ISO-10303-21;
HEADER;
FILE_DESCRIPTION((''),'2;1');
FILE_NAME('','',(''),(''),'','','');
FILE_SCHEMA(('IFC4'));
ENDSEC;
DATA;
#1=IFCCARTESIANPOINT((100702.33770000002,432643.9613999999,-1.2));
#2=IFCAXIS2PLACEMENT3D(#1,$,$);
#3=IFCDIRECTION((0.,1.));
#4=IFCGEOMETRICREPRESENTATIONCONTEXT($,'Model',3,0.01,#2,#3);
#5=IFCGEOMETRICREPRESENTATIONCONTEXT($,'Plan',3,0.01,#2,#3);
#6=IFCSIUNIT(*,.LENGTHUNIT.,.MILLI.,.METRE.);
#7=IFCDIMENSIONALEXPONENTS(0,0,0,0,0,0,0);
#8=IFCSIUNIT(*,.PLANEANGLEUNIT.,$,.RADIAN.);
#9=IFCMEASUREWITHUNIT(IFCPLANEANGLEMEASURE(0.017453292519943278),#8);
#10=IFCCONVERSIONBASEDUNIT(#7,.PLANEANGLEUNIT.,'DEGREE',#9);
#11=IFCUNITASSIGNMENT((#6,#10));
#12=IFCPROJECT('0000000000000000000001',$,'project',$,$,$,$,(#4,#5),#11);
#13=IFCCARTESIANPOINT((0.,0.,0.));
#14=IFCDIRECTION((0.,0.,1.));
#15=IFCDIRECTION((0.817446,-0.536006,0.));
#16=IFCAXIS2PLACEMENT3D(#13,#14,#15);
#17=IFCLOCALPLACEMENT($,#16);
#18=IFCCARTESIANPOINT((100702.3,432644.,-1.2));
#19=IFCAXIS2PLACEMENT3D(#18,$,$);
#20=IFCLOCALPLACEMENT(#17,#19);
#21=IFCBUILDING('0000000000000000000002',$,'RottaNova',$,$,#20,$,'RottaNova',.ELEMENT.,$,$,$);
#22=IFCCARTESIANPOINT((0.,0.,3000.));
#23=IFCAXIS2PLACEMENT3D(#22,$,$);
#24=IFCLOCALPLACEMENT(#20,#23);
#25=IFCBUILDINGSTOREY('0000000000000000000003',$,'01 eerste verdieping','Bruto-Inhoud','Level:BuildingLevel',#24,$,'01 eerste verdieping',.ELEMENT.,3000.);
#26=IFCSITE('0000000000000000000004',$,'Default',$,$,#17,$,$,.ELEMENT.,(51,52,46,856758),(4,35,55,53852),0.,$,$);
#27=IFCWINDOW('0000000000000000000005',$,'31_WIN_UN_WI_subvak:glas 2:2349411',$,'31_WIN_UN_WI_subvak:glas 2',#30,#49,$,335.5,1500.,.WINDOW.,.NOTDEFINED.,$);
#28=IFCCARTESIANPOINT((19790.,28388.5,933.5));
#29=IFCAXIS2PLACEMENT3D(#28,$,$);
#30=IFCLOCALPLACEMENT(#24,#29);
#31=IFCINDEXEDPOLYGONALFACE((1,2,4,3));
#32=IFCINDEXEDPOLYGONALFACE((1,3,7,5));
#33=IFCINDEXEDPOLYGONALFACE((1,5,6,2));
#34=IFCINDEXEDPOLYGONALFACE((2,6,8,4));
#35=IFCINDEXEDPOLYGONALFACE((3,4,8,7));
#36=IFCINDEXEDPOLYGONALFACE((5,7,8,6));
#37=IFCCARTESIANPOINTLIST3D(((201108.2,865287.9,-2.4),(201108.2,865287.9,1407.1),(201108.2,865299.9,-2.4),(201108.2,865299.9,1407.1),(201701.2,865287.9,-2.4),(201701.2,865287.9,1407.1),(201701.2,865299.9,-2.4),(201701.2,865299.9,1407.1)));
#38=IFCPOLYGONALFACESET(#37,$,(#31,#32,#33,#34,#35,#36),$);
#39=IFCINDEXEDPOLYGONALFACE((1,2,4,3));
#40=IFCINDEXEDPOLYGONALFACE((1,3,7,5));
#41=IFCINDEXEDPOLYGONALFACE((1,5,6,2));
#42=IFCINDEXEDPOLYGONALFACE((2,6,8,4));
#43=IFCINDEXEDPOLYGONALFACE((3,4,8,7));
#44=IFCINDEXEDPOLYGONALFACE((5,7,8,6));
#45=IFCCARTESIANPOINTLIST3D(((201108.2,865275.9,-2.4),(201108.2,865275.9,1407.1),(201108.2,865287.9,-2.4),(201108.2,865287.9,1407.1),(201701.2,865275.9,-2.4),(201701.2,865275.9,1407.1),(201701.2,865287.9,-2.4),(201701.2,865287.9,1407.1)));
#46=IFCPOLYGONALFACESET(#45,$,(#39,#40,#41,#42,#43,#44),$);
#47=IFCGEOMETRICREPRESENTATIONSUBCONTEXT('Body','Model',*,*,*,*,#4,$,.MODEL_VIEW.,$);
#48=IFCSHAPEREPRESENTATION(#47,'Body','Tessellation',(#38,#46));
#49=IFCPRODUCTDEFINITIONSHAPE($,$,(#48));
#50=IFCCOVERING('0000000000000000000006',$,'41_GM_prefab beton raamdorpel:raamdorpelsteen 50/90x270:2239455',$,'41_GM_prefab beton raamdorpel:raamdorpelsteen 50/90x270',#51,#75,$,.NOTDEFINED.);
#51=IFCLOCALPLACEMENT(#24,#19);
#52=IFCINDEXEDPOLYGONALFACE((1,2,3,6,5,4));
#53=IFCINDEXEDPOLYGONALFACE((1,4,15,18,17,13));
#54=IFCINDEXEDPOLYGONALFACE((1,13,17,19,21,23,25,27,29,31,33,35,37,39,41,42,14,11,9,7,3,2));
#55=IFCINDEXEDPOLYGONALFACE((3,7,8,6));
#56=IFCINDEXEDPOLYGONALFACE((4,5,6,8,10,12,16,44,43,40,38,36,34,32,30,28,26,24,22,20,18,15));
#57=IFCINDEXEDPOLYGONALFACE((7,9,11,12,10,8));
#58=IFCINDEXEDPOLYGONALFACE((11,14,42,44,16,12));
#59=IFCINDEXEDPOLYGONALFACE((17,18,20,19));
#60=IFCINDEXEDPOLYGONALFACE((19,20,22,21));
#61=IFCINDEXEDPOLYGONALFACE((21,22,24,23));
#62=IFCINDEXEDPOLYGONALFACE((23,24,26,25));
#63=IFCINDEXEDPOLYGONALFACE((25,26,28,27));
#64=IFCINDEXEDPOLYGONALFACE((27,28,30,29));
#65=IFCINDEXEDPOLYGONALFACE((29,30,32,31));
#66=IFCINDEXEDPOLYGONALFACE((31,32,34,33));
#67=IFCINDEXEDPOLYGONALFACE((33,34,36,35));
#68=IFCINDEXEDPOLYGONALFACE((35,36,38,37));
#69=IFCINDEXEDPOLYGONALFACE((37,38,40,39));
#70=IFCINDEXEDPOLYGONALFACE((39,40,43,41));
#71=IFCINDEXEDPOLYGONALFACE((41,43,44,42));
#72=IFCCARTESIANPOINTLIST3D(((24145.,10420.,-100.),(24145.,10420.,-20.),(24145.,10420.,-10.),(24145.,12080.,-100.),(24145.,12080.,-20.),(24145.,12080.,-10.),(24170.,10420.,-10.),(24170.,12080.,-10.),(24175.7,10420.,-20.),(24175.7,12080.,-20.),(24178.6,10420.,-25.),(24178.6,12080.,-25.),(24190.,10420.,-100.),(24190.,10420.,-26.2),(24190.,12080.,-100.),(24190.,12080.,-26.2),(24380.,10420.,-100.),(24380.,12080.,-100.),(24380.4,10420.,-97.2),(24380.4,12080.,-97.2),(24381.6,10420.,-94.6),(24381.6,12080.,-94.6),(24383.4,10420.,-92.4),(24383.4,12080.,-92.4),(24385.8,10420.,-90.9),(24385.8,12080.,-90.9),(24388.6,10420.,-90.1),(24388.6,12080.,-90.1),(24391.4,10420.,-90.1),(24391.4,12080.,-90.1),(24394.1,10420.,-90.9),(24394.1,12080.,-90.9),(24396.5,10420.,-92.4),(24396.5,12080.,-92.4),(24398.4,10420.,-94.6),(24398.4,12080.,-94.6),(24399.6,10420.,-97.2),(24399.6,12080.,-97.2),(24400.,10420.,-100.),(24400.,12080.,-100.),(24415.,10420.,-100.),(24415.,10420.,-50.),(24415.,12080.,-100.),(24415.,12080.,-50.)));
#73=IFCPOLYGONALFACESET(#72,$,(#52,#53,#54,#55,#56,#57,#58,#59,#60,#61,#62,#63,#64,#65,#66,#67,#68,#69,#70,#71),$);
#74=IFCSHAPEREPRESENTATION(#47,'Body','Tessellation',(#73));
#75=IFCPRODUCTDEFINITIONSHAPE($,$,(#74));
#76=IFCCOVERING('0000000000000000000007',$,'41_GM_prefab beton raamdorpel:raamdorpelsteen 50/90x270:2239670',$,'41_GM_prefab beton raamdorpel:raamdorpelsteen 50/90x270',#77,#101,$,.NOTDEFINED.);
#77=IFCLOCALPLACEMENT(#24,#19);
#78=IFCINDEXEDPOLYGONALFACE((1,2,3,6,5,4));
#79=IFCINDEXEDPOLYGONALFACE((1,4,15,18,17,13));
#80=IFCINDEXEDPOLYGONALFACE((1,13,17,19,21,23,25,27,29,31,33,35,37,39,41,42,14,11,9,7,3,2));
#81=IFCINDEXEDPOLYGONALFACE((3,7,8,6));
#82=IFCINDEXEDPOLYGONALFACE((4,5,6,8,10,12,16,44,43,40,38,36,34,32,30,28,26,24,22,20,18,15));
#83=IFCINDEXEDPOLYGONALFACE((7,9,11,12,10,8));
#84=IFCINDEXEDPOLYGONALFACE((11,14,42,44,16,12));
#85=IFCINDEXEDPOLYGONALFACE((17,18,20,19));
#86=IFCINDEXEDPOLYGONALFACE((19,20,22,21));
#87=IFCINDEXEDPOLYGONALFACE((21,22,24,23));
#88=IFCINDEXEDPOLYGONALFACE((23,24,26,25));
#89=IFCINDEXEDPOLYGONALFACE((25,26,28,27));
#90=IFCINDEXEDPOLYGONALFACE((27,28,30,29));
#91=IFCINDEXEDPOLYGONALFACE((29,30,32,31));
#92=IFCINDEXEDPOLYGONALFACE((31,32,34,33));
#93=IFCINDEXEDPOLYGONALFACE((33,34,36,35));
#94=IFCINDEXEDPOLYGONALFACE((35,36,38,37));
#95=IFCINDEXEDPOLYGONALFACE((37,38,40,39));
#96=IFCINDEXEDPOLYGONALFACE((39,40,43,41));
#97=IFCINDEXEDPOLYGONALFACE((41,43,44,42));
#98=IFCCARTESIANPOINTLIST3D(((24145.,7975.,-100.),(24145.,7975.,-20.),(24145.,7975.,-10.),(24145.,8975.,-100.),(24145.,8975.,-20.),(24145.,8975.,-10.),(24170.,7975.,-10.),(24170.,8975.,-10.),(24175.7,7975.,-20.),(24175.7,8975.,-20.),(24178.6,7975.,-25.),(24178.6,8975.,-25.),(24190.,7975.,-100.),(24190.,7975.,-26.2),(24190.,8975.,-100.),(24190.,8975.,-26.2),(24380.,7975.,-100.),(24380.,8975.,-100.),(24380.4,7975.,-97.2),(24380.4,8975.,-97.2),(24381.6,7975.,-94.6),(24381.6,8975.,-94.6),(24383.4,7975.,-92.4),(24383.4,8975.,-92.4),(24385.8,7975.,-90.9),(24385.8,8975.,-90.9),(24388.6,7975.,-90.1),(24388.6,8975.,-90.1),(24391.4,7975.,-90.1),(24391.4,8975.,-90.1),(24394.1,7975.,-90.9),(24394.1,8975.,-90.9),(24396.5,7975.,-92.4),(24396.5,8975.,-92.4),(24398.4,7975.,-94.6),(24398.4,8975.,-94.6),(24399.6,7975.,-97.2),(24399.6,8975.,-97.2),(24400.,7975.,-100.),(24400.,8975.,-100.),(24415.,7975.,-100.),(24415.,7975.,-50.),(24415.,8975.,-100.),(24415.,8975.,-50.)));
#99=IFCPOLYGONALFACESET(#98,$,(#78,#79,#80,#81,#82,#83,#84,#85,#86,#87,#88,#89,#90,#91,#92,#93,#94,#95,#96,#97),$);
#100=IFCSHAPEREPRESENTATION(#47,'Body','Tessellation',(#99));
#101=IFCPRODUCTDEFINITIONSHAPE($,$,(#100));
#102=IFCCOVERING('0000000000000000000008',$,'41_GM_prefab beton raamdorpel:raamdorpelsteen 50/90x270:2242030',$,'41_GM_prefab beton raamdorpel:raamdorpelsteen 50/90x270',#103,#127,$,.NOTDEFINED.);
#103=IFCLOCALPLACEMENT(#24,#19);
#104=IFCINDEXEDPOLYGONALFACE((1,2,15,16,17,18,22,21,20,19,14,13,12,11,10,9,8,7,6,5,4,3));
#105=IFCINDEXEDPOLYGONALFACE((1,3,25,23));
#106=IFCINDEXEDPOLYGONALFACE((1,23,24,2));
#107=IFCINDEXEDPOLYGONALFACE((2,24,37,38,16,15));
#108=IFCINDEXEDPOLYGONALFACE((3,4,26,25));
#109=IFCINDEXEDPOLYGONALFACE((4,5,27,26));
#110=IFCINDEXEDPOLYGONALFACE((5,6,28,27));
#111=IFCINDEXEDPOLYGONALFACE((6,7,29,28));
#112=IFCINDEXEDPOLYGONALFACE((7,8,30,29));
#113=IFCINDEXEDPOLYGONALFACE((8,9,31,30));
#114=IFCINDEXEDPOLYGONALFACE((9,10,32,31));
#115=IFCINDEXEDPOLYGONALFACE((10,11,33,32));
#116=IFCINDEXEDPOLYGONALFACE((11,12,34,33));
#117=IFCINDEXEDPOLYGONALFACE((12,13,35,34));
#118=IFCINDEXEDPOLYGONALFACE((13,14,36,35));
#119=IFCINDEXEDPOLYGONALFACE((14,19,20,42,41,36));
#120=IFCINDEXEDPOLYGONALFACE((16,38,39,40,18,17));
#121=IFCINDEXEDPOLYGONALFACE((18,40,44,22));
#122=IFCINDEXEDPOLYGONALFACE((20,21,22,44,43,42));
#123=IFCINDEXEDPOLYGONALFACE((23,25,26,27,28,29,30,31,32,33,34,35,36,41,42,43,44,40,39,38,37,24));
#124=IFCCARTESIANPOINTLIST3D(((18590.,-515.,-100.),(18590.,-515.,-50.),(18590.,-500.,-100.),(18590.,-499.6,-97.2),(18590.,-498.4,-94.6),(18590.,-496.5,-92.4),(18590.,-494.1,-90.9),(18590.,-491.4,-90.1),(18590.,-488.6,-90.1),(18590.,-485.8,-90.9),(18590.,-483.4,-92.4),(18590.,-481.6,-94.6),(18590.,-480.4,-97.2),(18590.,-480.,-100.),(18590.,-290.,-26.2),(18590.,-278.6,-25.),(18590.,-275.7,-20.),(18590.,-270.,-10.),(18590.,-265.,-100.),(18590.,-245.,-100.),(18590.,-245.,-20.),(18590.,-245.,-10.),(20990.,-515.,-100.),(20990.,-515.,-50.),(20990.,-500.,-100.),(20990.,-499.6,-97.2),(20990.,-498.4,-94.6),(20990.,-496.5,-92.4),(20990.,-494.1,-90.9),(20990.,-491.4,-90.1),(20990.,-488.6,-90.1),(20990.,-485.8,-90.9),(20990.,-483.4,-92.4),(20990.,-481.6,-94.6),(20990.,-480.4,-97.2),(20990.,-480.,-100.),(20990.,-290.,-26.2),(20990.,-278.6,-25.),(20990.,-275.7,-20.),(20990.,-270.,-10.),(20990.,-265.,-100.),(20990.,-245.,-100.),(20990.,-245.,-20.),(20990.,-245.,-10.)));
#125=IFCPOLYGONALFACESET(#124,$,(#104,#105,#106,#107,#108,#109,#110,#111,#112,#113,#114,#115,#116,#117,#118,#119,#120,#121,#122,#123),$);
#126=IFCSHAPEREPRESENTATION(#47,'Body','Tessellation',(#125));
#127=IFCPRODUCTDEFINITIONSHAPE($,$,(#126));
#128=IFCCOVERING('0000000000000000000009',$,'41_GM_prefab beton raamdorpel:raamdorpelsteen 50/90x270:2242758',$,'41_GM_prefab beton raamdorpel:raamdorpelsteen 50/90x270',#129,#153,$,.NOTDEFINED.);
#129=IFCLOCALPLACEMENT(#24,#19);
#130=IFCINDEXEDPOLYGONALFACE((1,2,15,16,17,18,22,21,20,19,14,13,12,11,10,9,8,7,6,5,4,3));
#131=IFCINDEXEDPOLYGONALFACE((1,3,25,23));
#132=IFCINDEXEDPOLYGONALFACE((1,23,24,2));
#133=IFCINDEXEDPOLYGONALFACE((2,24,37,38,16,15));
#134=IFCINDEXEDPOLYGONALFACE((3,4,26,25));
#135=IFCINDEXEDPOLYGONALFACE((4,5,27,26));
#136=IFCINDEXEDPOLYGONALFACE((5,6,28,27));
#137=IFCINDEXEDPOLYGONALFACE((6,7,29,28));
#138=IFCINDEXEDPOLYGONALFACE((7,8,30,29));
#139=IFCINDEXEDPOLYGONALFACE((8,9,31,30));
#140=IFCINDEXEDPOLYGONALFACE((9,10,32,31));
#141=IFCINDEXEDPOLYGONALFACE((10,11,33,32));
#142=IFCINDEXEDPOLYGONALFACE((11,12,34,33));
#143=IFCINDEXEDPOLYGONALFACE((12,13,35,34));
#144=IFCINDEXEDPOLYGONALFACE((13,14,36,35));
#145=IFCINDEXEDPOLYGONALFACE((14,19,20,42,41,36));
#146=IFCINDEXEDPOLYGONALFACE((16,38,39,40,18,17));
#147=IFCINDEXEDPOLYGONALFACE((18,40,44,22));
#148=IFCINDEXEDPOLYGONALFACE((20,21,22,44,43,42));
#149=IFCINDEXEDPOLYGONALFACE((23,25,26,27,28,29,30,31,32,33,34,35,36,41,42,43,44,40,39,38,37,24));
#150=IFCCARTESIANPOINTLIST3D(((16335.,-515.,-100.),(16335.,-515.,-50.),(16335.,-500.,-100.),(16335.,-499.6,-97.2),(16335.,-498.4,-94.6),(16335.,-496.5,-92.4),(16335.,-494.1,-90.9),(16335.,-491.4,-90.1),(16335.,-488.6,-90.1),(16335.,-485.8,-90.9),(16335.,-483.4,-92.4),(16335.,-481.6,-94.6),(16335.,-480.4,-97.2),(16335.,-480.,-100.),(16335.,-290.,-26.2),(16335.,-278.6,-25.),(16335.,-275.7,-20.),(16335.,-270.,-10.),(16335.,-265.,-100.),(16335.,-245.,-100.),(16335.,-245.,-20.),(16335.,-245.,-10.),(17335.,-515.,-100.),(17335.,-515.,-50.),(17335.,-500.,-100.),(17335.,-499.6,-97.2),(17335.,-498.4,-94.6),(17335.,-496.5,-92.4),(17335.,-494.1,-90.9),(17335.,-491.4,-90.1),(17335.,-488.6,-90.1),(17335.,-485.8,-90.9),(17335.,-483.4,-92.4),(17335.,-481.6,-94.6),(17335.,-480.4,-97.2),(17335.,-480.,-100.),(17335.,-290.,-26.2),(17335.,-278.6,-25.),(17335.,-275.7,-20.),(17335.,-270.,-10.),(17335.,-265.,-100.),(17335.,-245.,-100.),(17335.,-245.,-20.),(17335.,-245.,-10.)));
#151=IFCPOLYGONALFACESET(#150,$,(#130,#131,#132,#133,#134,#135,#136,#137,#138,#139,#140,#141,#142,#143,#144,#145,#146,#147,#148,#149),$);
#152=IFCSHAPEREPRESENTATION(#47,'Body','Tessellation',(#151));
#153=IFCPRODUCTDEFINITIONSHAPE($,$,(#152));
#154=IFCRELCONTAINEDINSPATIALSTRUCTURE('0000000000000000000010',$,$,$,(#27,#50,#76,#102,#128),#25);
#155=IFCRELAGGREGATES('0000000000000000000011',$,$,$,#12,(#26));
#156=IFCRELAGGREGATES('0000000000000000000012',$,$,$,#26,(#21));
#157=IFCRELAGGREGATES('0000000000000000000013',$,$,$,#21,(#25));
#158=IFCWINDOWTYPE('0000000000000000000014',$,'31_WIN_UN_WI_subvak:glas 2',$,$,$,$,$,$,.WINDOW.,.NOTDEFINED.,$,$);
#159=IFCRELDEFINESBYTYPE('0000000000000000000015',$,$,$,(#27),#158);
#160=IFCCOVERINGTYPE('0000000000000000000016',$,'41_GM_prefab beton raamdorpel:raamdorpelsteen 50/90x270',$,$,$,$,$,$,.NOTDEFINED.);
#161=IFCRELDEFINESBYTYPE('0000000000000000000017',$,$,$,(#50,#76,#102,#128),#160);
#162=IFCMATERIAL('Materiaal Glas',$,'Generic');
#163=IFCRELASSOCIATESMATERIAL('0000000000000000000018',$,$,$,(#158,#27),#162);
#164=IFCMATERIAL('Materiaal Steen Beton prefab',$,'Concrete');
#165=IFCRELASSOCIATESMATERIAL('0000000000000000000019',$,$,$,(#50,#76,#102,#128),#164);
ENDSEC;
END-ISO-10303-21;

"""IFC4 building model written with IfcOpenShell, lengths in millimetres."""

from ifc_helpers import new_model, entity, si_unit, converted_unit, direction, frame, place, context, subcontext, project, spatial, line, arc, indexed_curve, outline, extrude, source, transform, mapped, material, type_object, type_shapes, element, save


model = new_model("IFC4")

# Units and contexts
model_context = context("Model", 3, precision=0.01, world=frame((100702.33770000002, 432643.9613999999, -1.2)), true_north=direction((0.0, 1.0)))
plan_context = context("Plan", 3, precision=0.01, world=frame((100702.33770000002, 432643.9613999999, -1.2)), true_north=direction((0.0, 1.0)))
body_context = subcontext(model_context, "Body", "Model", "MODEL_VIEW")
ifc_project = project(units=[si_unit("LENGTHUNIT", "METRE", prefix="MILLI"), converted_unit("PLANEANGLEUNIT", "DEGREE", entity("IfcPlaneAngleMeasure", 0.017453292519943278), si_unit("PLANEANGLEUNIT", "RADIAN"), dimensions=[0, 0, 0, 0, 0, 0, 0])], contexts=[model_context, plan_context])

# Site, building, storey
site_placement = place(None, frame((0.0, 0.0, 0.0), z_axis=(0.0, 0.0, 1.0), x_axis=(0.817446, -0.536006, 0.0)))
site = spatial("IfcSite", under=ifc_project, at=site_placement, Name="Default", CompositionType="ELEMENT", RefLatitude=(51, 52, 46, 856758), RefLongitude=(4, 35, 55, 53852), RefElevation=0.0)
building_placement = place(site_placement, frame((100702.3, 432644.0, -1.2)))
building = spatial("IfcBuilding", under=site, at=building_placement, Name="RottaNova", LongName="RottaNova", CompositionType="ELEMENT")
storey_placement = place(building_placement, frame((0.0, 0.0, 3000.0)))
storey = spatial("IfcBuildingStorey", under=building, at=storey_placement, Name="01 eerste verdieping", Description="Bruto-Inhoud", ObjectType="Level:BuildingLevel", LongName="01 eerste verdieping", CompositionType="ELEMENT", Elevation=3000.0)

# Shared definitions
ifc_material_1 = material(Name="Materiaal Steen Beton prefab", Category="Concrete")

# Window
ifc_material_2 = material(Name="Materiaal Glas", Category="Generic")
window_type = type_object("IfcWindowType", Name="31_WIN_UN_WI_subvak:glas 2", PartitioningType="NOTDEFINED", PredefinedType="WINDOW", material=ifc_material_2)
shared_shape_1 = source(frame((100702.3, 432644.0, -1.2)), body_context, "Body", "SweptSolid", [
    extrude(outline(indexed_curve([(-6.0, -296.5), (6.0, -296.5), (6.0, 296.5), (-6.0, 296.5), (-6.0, -296.5)], self_intersect=False)), frame((0.0, 6.0, 0.0), z_axis=(0.0, 0.0, 1.0), x_axis=(0.0, -1.0, 0.0)), (0.0, 0.0, 1.0), 1409.5),
    extrude(outline(indexed_curve([(-6.0, -296.5), (6.0, -296.5), (6.0, 296.5), (-6.0, 296.5), (-6.0, -296.5)], self_intersect=False)), frame((0.0, -6.0, 0.0), z_axis=(0.0, 0.0, 1.0), x_axis=(0.0, -1.0, 0.0)), (0.0, 0.0, 1.0), 1409.5),
])
type_shapes(window_type, [shared_shape_1])
window_1_placement = place(storey_placement, frame((19790.0, 28388.5, 933.5)))
element("IfcWindow", 1, at=window_1_placement, inside=storey, type_object=window_type, material=ifc_material_2, Name="31_WIN_UN_WI_subvak:glas 2:2349411", ObjectType="31_WIN_UN_WI_subvak:glas 2", OverallHeight=335.5, OverallWidth=1500.0, PartitioningType="NOTDEFINED", PredefinedType="WINDOW", context=body_context, shape_type="MappedRepresentation", body=[
    mapped(shared_shape_1, transform((100702.3, 432644.0, -1.2), scale=1.0)),
])

# Coverings
covering_type = type_object("IfcCoveringType", Name="41_GM_prefab beton raamdorpel:raamdorpelsteen 50/90x270", PredefinedType="NOTDEFINED")
covering_1_placement = place(storey_placement, frame((100702.3, 432644.0, -1.2)))
element("IfcCovering", 2, at=covering_1_placement, inside=storey, type_object=covering_type, material=ifc_material_1, Name="41_GM_prefab beton raamdorpel:raamdorpelsteen 50/90x270:2239455", ObjectType="41_GM_prefab beton raamdorpel:raamdorpelsteen 50/90x270", PredefinedType="NOTDEFINED", context=body_context, shape_type="SweptSolid", body=[
    extrude(outline(indexed_curve([(-77.0, -43.1), (-89.5, -64.7), (-80.8, -69.7), (-11.5, -109.7), (11.0, -70.7), (106.0, 93.8), (102.3, 107.5), (116.0, 111.1), (123.5, 124.1), (80.2, 149.1), (-52.9, -33.8), (-59.6, -43.1), (-65.4, -43.1)], segments=[line(1, 2, 3, 4, 5, 6), arc(6, 7, 8), line(8, 9, 10, 11, 12, 13, 1)], self_intersect=False)), frame((24245.8, 10420.0, -55.1), z_axis=(0.0, -1.0, 0.0), x_axis=(0.5, 0.0, -0.866025)), (0.0, 0.0, -1.0), 1660.0),
])
covering_2_placement = place(storey_placement, frame((100702.3, 432644.0, -1.2)))
element("IfcCovering", 3, at=covering_2_placement, inside=storey, type_object=covering_type, material=ifc_material_1, Name="41_GM_prefab beton raamdorpel:raamdorpelsteen 50/90x270:2239670", ObjectType="41_GM_prefab beton raamdorpel:raamdorpelsteen 50/90x270", PredefinedType="NOTDEFINED", context=body_context, shape_type="SweptSolid", body=[
    extrude(outline(indexed_curve([(-77.0, -43.1), (-89.5, -64.7), (-80.8, -69.7), (-11.5, -109.7), (11.0, -70.7), (106.0, 93.8), (102.3, 107.5), (116.0, 111.1), (123.5, 124.1), (80.2, 149.1), (-52.9, -33.8), (-59.6, -43.1), (-65.4, -43.1)], segments=[line(1, 2, 3, 4, 5, 6), arc(6, 7, 8), line(8, 9, 10, 11, 12, 13, 1)], self_intersect=False)), frame((24245.8, 7975.0, -55.1), z_axis=(0.0, -1.0, 0.0), x_axis=(0.5, 0.0, -0.866025)), (0.0, 0.0, -1.0), 1000.0),
])
covering_3_placement = place(storey_placement, frame((100702.3, 432644.0, -1.2)))
element("IfcCovering", 4, at=covering_3_placement, inside=storey, type_object=covering_type, material=ifc_material_1, Name="41_GM_prefab beton raamdorpel:raamdorpelsteen 50/90x270:2242030", ObjectType="41_GM_prefab beton raamdorpel:raamdorpelsteen 50/90x270", PredefinedType="NOTDEFINED", context=body_context, shape_type="SweptSolid", body=[
    extrude(outline(indexed_curve([(-75.9, -41.3), (-88.4, -62.9), (-79.8, -67.9), (-10.5, -107.9), (-0.5, -90.6), (107.0, 95.6), (103.4, 109.3), (117.0, 112.9), (124.5, 125.9), (81.2, 150.9), (-51.9, -32.0), (-58.6, -41.3), (-64.4, -41.3)], segments=[line(1, 2, 3, 4, 5, 6), arc(6, 7, 8), line(8, 9, 10, 11, 12, 13, 1)], self_intersect=False)), frame((18590.0, -343.7, -55.1), z_axis=(-1.0, 0.0, 0.0), x_axis=(0.0, -0.5, -0.866025)), (0.0, 0.0, -1.0), 2400.0),
])
covering_4_placement = place(storey_placement, frame((100702.3, 432644.0, -1.2)))
element("IfcCovering", 5, at=covering_4_placement, inside=storey, type_object=covering_type, material=ifc_material_1, Name="41_GM_prefab beton raamdorpel:raamdorpelsteen 50/90x270:2242758", ObjectType="41_GM_prefab beton raamdorpel:raamdorpelsteen 50/90x270", PredefinedType="NOTDEFINED", context=body_context, shape_type="SweptSolid", body=[
    extrude(outline(indexed_curve([(-75.9, -41.3), (-88.4, -62.9), (-79.8, -67.9), (-10.5, -107.9), (-0.5, -90.6), (107.0, 95.6), (103.4, 109.3), (117.0, 112.9), (124.5, 125.9), (81.2, 150.9), (-51.9, -32.0), (-58.6, -41.3), (-64.4, -41.3)], segments=[line(1, 2, 3, 4, 5, 6), arc(6, 7, 8), line(8, 9, 10, 11, 12, 13, 1)], self_intersect=False)), frame((16335.0, -343.7, -55.1), z_axis=(-1.0, 0.0, 0.0), x_axis=(0.0, -0.5, -0.866025)), (0.0, 0.0, -1.0), 1000.0),
])

save(model, "model.ifc")
